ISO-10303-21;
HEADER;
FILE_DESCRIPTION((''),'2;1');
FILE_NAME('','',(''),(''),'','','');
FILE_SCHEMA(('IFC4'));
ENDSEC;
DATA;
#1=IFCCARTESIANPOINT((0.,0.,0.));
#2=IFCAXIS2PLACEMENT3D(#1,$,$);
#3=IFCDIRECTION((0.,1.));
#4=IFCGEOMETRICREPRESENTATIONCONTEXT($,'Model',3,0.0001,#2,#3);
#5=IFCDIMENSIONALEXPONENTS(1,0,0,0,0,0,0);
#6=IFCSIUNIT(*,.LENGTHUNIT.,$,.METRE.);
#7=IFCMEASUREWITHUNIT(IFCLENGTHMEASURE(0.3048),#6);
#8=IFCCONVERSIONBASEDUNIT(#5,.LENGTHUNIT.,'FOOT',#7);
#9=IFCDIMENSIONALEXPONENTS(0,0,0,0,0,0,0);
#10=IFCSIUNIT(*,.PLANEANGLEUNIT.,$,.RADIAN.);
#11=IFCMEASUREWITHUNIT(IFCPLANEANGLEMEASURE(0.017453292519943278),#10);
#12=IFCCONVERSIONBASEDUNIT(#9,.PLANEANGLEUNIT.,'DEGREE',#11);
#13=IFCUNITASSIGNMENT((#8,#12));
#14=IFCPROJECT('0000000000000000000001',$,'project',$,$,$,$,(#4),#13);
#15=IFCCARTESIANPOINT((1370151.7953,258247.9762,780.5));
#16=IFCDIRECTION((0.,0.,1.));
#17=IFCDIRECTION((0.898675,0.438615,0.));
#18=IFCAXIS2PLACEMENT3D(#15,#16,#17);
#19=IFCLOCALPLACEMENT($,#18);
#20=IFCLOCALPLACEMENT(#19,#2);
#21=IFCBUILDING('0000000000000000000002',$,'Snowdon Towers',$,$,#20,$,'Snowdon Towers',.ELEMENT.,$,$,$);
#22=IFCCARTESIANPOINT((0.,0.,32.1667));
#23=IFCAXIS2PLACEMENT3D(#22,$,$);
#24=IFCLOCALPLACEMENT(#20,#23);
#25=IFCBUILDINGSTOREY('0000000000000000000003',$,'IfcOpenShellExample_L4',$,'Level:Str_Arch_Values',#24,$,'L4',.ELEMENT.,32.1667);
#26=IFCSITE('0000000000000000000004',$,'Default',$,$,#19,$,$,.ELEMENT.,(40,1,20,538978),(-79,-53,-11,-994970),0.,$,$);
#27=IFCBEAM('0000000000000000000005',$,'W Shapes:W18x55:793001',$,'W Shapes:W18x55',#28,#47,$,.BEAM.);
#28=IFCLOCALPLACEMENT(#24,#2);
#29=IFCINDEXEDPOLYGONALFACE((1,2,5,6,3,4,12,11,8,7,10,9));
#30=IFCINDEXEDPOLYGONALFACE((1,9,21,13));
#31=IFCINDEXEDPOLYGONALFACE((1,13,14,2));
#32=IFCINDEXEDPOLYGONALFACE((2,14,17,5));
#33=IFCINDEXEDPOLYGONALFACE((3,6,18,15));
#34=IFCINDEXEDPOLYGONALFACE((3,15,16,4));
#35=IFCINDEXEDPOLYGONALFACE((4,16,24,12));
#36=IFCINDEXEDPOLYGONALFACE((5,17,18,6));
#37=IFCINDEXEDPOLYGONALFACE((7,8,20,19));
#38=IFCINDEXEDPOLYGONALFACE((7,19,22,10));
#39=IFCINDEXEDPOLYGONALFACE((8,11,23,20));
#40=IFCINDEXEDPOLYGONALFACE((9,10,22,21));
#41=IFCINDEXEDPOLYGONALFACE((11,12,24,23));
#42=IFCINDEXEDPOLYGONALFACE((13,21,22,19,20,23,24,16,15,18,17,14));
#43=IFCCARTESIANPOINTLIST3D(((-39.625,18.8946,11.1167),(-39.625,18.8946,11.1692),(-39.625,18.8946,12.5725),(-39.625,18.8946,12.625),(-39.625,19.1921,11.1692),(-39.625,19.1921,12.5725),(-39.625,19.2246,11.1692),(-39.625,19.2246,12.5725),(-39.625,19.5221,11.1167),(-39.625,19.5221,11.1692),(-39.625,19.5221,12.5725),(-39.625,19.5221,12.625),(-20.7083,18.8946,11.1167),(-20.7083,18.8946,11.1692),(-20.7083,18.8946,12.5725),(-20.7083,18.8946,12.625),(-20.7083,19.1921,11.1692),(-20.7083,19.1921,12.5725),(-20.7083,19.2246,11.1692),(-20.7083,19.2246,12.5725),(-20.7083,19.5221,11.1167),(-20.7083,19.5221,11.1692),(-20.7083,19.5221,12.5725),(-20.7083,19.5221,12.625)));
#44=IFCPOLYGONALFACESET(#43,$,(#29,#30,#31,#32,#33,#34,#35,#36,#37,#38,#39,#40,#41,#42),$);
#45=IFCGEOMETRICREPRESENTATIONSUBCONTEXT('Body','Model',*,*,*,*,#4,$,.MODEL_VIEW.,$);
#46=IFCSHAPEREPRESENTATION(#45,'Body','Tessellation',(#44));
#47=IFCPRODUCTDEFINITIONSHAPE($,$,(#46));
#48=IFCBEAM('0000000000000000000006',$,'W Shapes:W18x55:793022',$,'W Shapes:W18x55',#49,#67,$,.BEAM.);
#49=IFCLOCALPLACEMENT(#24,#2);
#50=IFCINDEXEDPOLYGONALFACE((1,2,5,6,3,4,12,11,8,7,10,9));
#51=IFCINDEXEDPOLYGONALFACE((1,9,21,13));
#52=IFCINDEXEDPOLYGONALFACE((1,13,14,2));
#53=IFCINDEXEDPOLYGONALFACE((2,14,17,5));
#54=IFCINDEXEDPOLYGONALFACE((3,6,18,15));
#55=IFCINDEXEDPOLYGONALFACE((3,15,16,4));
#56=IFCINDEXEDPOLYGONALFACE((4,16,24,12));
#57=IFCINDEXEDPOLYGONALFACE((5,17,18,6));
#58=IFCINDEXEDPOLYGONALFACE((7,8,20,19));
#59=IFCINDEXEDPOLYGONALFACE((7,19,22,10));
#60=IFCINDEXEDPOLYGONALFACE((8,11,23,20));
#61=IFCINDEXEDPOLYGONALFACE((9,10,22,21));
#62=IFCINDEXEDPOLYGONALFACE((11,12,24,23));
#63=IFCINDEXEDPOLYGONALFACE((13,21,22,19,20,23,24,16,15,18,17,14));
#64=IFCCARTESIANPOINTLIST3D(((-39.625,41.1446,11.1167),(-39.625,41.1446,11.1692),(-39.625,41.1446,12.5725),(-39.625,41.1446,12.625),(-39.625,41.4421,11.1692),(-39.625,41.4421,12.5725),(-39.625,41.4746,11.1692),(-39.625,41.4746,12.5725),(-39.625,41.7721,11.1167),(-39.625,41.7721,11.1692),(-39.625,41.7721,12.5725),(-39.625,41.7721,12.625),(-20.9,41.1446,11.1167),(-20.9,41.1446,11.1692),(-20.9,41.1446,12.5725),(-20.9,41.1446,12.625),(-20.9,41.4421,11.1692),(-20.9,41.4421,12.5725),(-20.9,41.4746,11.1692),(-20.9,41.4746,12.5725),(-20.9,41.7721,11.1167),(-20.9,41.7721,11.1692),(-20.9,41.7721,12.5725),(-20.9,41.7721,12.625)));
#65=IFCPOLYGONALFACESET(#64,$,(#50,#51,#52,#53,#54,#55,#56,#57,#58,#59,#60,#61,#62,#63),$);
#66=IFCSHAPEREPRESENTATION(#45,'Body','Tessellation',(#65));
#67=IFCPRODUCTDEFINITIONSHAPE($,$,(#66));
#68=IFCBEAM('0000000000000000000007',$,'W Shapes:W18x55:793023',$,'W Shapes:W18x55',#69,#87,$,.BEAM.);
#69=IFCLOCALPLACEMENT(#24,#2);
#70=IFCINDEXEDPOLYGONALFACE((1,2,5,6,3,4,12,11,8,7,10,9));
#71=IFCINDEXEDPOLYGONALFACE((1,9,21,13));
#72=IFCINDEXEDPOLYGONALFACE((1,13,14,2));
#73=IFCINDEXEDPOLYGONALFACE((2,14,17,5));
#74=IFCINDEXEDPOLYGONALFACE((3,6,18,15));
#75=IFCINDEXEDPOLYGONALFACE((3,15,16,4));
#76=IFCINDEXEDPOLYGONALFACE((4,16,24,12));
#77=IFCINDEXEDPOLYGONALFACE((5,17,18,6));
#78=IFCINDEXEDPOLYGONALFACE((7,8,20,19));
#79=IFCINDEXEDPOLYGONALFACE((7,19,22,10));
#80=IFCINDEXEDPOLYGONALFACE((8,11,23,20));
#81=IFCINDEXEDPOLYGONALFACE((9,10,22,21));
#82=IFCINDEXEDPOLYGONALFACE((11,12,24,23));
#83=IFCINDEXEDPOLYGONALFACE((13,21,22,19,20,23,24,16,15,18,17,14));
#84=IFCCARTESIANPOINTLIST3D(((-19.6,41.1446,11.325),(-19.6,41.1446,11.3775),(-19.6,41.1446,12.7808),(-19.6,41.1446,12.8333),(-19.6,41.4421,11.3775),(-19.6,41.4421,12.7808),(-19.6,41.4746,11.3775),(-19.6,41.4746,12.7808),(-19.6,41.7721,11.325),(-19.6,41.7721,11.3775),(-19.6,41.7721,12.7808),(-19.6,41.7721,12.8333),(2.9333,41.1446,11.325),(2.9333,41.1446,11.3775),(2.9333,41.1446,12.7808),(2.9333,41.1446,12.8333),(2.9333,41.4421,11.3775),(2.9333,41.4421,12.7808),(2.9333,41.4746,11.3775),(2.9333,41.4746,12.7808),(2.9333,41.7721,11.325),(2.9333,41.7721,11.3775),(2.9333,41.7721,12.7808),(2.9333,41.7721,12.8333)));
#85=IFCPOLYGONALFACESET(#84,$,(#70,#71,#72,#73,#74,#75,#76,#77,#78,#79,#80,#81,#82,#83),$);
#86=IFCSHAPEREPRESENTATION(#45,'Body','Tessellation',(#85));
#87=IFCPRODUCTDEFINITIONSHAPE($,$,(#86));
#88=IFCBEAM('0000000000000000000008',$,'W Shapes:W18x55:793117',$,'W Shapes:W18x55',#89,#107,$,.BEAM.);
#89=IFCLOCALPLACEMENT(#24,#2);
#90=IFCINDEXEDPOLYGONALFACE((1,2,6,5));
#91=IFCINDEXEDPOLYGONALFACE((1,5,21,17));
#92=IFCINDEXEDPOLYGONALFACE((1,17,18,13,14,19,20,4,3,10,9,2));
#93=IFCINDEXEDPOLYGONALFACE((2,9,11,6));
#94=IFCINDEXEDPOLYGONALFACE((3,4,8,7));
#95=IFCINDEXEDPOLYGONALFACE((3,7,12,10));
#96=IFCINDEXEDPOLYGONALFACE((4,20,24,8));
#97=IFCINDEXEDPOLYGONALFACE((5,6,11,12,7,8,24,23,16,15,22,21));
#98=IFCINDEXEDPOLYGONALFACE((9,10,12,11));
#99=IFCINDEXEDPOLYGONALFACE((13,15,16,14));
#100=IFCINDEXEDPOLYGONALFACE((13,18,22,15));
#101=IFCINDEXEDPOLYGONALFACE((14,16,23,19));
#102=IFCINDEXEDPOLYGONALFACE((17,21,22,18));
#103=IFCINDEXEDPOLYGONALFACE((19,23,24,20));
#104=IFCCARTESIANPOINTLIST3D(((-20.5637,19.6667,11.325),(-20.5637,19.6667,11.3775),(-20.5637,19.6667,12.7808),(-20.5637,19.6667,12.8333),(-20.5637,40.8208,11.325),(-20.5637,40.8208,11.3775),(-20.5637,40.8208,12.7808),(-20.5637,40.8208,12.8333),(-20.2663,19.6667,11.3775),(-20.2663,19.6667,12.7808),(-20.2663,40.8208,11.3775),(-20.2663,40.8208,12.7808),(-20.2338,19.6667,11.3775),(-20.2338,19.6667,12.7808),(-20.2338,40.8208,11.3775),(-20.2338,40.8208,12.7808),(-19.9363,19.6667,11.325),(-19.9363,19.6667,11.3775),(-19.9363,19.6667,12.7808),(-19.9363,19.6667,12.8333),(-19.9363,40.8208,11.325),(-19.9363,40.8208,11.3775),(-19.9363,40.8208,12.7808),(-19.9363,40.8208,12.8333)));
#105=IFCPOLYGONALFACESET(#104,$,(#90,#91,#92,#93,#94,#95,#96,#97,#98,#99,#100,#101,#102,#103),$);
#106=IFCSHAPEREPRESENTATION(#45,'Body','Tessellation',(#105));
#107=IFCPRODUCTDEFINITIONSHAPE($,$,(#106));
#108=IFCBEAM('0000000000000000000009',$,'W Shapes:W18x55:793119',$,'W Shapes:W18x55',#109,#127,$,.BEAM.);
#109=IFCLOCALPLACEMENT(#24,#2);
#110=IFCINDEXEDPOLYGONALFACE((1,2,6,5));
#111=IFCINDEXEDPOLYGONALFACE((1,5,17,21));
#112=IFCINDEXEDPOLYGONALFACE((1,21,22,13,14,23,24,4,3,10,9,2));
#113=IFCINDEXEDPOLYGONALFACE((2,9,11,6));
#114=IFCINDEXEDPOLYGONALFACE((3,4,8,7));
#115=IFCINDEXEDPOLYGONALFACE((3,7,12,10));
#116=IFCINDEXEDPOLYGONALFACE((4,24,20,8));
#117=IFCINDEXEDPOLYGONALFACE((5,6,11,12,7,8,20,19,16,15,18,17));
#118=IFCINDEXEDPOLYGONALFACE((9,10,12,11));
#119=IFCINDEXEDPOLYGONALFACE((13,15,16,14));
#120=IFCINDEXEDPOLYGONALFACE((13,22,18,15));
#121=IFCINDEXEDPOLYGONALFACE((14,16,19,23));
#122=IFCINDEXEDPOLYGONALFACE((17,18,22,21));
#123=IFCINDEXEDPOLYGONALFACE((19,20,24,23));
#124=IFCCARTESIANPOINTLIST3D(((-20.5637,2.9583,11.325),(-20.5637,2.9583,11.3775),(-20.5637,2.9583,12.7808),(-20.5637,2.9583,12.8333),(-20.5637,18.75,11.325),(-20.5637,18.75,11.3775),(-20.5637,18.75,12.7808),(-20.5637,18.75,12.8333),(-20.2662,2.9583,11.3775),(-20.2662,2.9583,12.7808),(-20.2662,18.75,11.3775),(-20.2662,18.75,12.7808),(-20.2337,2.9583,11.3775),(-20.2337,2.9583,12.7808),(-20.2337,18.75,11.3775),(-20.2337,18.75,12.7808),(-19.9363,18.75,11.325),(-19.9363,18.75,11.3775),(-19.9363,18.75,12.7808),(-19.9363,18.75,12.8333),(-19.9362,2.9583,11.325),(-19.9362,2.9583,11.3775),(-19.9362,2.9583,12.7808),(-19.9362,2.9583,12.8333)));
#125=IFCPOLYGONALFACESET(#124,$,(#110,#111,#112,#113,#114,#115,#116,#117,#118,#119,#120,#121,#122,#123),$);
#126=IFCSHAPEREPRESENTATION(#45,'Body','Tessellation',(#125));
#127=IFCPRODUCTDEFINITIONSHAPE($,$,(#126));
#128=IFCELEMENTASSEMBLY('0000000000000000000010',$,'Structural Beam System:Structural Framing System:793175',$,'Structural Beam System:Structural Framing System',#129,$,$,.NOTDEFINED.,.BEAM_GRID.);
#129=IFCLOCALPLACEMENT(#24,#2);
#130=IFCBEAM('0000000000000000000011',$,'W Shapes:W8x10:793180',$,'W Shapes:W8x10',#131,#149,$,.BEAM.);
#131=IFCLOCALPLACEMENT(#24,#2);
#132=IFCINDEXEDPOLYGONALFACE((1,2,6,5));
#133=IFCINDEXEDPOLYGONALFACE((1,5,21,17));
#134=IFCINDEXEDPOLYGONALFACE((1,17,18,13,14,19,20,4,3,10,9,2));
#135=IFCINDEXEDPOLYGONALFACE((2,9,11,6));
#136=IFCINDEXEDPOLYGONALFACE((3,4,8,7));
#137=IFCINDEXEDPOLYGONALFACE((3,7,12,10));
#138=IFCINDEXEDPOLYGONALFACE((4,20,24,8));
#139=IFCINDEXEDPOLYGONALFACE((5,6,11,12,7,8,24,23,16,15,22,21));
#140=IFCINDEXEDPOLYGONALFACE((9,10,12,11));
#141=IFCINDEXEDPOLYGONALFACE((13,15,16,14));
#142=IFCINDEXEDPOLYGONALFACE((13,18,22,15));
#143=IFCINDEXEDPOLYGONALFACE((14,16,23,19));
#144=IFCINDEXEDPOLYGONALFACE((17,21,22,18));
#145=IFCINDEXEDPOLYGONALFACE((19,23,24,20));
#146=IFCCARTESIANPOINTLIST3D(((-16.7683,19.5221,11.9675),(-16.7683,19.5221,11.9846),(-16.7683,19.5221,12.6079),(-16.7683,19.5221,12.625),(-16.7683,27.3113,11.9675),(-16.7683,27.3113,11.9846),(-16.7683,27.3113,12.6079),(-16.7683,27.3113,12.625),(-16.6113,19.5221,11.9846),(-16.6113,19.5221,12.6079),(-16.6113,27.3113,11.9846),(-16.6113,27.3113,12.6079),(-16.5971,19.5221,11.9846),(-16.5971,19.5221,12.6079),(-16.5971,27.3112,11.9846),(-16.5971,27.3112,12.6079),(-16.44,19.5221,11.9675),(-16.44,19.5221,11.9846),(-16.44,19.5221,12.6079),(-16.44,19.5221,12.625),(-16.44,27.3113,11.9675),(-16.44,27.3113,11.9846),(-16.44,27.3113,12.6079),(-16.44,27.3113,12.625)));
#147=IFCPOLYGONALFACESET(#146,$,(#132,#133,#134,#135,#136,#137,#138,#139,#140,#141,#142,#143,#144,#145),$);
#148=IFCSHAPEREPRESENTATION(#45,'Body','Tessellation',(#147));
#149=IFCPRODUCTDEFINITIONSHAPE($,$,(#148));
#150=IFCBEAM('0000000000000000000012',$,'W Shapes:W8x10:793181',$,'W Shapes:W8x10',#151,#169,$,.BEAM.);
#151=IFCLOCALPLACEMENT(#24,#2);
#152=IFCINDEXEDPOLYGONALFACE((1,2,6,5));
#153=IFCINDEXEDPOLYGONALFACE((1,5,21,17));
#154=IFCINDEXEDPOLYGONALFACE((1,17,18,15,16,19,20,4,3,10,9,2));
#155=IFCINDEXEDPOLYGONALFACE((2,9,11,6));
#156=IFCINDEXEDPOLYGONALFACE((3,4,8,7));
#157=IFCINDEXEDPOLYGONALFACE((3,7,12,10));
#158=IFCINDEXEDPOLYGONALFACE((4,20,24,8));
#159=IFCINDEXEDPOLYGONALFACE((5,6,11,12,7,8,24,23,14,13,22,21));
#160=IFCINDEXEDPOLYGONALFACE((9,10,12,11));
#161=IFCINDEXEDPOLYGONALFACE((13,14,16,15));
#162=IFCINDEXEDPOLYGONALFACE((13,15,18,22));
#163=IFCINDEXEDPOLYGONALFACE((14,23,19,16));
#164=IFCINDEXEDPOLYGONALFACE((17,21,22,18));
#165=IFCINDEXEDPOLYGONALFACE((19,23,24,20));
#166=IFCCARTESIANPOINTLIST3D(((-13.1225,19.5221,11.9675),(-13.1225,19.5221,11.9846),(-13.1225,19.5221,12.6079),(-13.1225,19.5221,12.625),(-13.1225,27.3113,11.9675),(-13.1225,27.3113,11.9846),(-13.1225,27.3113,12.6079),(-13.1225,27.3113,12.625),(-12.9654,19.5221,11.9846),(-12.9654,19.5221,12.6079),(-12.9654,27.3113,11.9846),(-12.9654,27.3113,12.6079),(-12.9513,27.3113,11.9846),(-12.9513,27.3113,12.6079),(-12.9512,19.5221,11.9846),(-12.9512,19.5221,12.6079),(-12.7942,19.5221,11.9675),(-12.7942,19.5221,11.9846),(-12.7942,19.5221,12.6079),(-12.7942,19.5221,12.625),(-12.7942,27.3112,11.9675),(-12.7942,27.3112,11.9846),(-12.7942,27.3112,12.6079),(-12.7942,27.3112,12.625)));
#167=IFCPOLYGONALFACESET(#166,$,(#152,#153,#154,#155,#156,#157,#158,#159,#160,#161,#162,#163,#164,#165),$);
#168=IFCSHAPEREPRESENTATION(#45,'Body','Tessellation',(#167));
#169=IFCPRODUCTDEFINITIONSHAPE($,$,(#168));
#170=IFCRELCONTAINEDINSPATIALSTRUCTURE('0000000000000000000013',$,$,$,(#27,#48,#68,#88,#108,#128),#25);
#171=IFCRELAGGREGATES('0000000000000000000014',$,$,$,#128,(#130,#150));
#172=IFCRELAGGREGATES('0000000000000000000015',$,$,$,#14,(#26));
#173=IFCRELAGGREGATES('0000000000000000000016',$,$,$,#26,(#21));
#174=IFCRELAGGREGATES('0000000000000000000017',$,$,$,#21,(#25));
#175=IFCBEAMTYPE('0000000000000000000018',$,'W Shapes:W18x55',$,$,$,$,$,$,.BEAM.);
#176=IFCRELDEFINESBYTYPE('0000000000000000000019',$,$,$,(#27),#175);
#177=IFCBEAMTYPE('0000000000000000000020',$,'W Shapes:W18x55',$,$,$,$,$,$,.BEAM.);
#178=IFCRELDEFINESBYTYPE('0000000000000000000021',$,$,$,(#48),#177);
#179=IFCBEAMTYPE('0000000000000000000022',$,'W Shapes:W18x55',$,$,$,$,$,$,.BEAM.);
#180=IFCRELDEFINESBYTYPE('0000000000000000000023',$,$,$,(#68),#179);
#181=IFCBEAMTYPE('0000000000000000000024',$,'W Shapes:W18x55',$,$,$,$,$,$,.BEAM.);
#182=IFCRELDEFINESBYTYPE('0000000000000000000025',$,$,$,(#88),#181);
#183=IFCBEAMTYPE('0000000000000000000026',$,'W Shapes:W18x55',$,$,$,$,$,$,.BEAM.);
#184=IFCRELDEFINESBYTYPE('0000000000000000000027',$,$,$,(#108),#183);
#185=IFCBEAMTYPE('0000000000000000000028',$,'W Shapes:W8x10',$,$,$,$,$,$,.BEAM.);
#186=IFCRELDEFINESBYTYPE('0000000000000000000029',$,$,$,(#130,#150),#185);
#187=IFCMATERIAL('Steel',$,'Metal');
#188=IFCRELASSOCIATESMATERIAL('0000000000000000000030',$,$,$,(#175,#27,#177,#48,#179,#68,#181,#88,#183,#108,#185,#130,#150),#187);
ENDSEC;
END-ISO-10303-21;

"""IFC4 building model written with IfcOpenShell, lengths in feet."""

from ifc_helpers import new_model, entity, si_unit, converted_unit, direction, frame, origin, place, context, subcontext, project, spatial, indexed_curve, outline, extrude, source, transform, mapped, material, type_object, type_shapes, element, aggregate, save


model = new_model("IFC4")

# Units and contexts
model_context = context("Model", 3, precision=0.0001, world=origin(), true_north=direction((0.0, 1.0)))
body_context = subcontext(model_context, "Body", "Model", "MODEL_VIEW")
ifc_project = project(units=[converted_unit("LENGTHUNIT", "FOOT", entity("IfcLengthMeasure", 0.3048), si_unit("LENGTHUNIT", "METRE"), dimensions=[1, 0, 0, 0, 0, 0, 0]), converted_unit("PLANEANGLEUNIT", "DEGREE", entity("IfcPlaneAngleMeasure", 0.017453292519943278), si_unit("PLANEANGLEUNIT", "RADIAN"), dimensions=[0, 0, 0, 0, 0, 0, 0])], contexts=[model_context])

# Site, building, storey
site_placement = place(None, frame((1370151.7953, 258247.9762, 780.5), z_axis=(0.0, 0.0, 1.0), x_axis=(0.898675, 0.438615, 0.0)))
site = spatial("IfcSite", under=ifc_project, at=site_placement, Name="Default", CompositionType="ELEMENT", RefLatitude=(40, 1, 20, 538978), RefLongitude=(-79, -53, -11, -994970), RefElevation=0.0)
building_placement = place(site_placement, origin())
building = spatial("IfcBuilding", under=site, at=building_placement, Name="Snowdon Towers", LongName="Snowdon Towers", CompositionType="ELEMENT")
storey_placement = place(building_placement, frame((0.0, 0.0, 32.1667)))
storey = spatial("IfcBuildingStorey", under=building, at=storey_placement, Name="IfcOpenShellExample_L4", ObjectType="Level:Str_Arch_Values", LongName="L4", CompositionType="ELEMENT", Elevation=32.1667)

# Shared definitions
ifc_material = material(Name="Steel", Category="Metal")

# Beams
beam_type_1 = type_object("IfcBeamType", Name="W Shapes:W18x55", PredefinedType="BEAM", material=ifc_material)
shared_shape_1 = source(origin(), body_context, "Body", "SweptSolid", [
    extrude(outline(indexed_curve([(-0.3138, -0.7017), (-0.3138, -0.7542), (0.3138, -0.7542), (0.3138, -0.7017), (0.0162, -0.7017), (0.0162, 0.7017), (0.3138, 0.7017), (0.3138, 0.7542), (-0.3137, 0.7542), (-0.3137, 0.7017), (-0.0163, 0.7017), (-0.0163, -0.7017), (-0.3138, -0.7017)], self_intersect=False)), frame((-9.5625, 0.0, 0.0), z_axis=(-1.0, 0.0, 0.0), x_axis=(0.0, -1.0, 0.0)), (0.0, 0.0, -1.0), 18.9167),
])
type_shapes(beam_type_1, [shared_shape_1])
beam_1_placement = place(storey_placement, frame((-30.0625, 19.2083, 11.8708)))
element("IfcBeam", 1, at=beam_1_placement, inside=storey, type_object=beam_type_1, material=ifc_material, Name="W Shapes:W18x55:793001", ObjectType="W Shapes:W18x55", PredefinedType="BEAM", context=body_context, shape_type="MappedRepresentation", body=[
    mapped(shared_shape_1, transform((0.0, 0.0, 0.0), scale=1.0)),
])
beam_type_2 = type_object("IfcBeamType", Name="W Shapes:W18x55", PredefinedType="BEAM", material=ifc_material)
shared_shape_2 = source(origin(), body_context, "Body", "SweptSolid", [
    extrude(outline(indexed_curve([(-0.3138, -0.7017), (-0.3138, -0.7542), (0.3138, -0.7542), (0.3138, -0.7017), (0.0162, -0.7017), (0.0162, 0.7017), (0.3138, 0.7017), (0.3138, 0.7542), (-0.3137, 0.7542), (-0.3137, 0.7017), (-0.0163, 0.7017), (-0.0163, -0.7017), (-0.3138, -0.7017)], self_intersect=False)), frame((-9.5625, 0.0, 0.0), z_axis=(-1.0, 0.0, 0.0), x_axis=(0.0, -1.0, 0.0)), (0.0, 0.0, -1.0), 18.725),
])
type_shapes(beam_type_2, [shared_shape_2])
beam_2_placement = place(storey_placement, frame((-30.0625, 41.4583, 11.8708)))
element("IfcBeam", 2, at=beam_2_placement, inside=storey, type_object=beam_type_2, material=ifc_material, Name="W Shapes:W18x55:793022", ObjectType="W Shapes:W18x55", PredefinedType="BEAM", context=body_context, shape_type="MappedRepresentation", body=[
    mapped(shared_shape_2, transform((0.0, 0.0, 0.0), scale=1.0)),
])
beam_type_3 = type_object("IfcBeamType", Name="W Shapes:W18x55", PredefinedType="BEAM", material=ifc_material)
shared_shape_3 = source(origin(), body_context, "Body", "SweptSolid", [
    extrude(outline(indexed_curve([(-0.3138, -0.7017), (-0.3138, -0.7542), (0.3138, -0.7542), (0.3138, -0.7017), (0.0162, -0.7017), (0.0162, 0.7017), (0.3138, 0.7017), (0.3138, 0.7542), (-0.3137, 0.7542), (-0.3137, 0.7017), (-0.0163, 0.7017), (-0.0163, -0.7017), (-0.3138, -0.7017)], self_intersect=False)), frame((-11.35, 0.0, 0.0), z_axis=(-1.0, 0.0, 0.0), x_axis=(0.0, -1.0, 0.0)), (0.0, 0.0, -1.0), 22.5333),
])
type_shapes(beam_type_3, [shared_shape_3])
beam_3_placement = place(storey_placement, frame((-8.25, 41.4583, 12.0792)))
element("IfcBeam", 3, at=beam_3_placement, inside=storey, type_object=beam_type_3, material=ifc_material, Name="W Shapes:W18x55:793023", ObjectType="W Shapes:W18x55", PredefinedType="BEAM", context=body_context, shape_type="MappedRepresentation", body=[
    mapped(shared_shape_3, transform((0.0, 0.0, 0.0), scale=1.0)),
])
beam_type_4 = type_object("IfcBeamType", Name="W Shapes:W18x55", PredefinedType="BEAM", material=ifc_material)
shared_shape_4 = source(origin(), body_context, "Body", "SweptSolid", [
    extrude(outline(indexed_curve([(-0.3138, -0.7017), (-0.3138, -0.7542), (0.3138, -0.7542), (0.3138, -0.7017), (0.0162, -0.7017), (0.0162, 0.7017), (0.3138, 0.7017), (0.3138, 0.7542), (-0.3137, 0.7542), (-0.3137, 0.7017), (-0.0163, 0.7017), (-0.0163, -0.7017), (-0.3138, -0.7017)], self_intersect=False)), frame((-10.4042, 0.0, 0.0), z_axis=(-1.0, 0.0, 0.0), x_axis=(0.0, -1.0, 0.0)), (0.0, 0.0, -1.0), 21.1542),
])
type_shapes(beam_type_4, [shared_shape_4])
beam_4_placement = place(storey_placement, frame((-20.25, 30.4167, 12.0792), z_axis=(0.0, 0.0, 1.0), x_axis=(0.0, -1.0, 0.0)))
element("IfcBeam", 4, at=beam_4_placement, inside=storey, type_object=beam_type_4, material=ifc_material, Name="W Shapes:W18x55:793117", ObjectType="W Shapes:W18x55", PredefinedType="BEAM", context=body_context, shape_type="MappedRepresentation", body=[
    mapped(shared_shape_4, transform((0.0, 0.0, 0.0), scale=1.0)),
])
beam_type_5 = type_object("IfcBeamType", Name="W Shapes:W18x55", PredefinedType="BEAM", material=ifc_material)
shared_shape_5 = source(origin(), body_context, "Body", "SweptSolid", [
    extrude(outline(indexed_curve([(-0.3138, -0.7017), (-0.3138, -0.7542), (0.3138, -0.7542), (0.3138, -0.7017), (0.0162, -0.7017), (0.0162, 0.7017), (0.3138, 0.7017), (0.3138, 0.7542), (-0.3137, 0.7542), (-0.3137, 0.7017), (-0.0163, 0.7017), (-0.0163, -0.7017), (-0.3138, -0.7017)], self_intersect=False)), frame((-7.8958, 0.0, 0.0), z_axis=(-1.0, 0.0, 0.0), x_axis=(0.0, -1.0, 0.0)), (0.0, 0.0, -1.0), 15.7917),
])
type_shapes(beam_type_5, [shared_shape_5])
beam_5_placement = place(storey_placement, frame((-20.25, 10.8542, 12.0792), z_axis=(0.0, 0.0, 1.0), x_axis=(0.0, -1.0, 0.0)))
element("IfcBeam", 5, at=beam_5_placement, inside=storey, type_object=beam_type_5, material=ifc_material, Name="W Shapes:W18x55:793119", ObjectType="W Shapes:W18x55", PredefinedType="BEAM", context=body_context, shape_type="MappedRepresentation", body=[
    mapped(shared_shape_5, transform((0.0, 0.0, 0.0), scale=1.0)),
])

# Element assembly, beams
assembly_1_placement = place(storey_placement, origin())
assembly_1 = element("IfcElementAssembly", 6, at=assembly_1_placement, inside=storey, Name="Structural Beam System:Structural Framing System:793175", ObjectType="Structural Beam System:Structural Framing System", AssemblyPlace="NOTDEFINED", PredefinedType="BEAM_GRID")
beam_type_6 = type_object("IfcBeamType", Name="W Shapes:W8x10", PredefinedType="BEAM", material=ifc_material)
shared_shape_6 = source(origin(), body_context, "Body", "SweptSolid", [
    extrude(outline(indexed_curve([(-0.1642, -0.3117), (-0.1642, -0.3288), (0.1642, -0.3288), (0.1642, -0.3117), (0.0071, -0.3117), (0.0071, 0.3117), (0.1642, 0.3117), (0.1642, 0.3287), (-0.1642, 0.3287), (-0.1642, 0.3117), (-0.0071, 0.3117), (-0.0071, -0.3117), (-0.1642, -0.3117)], self_intersect=False)), frame((-3.8946, 0.0, 0.0), z_axis=(-1.0, 0.0, 0.0), x_axis=(0.0, -1.0, 0.0)), (0.0, 0.0, -1.0), 7.7892),
])
type_shapes(beam_type_6, [shared_shape_6])
beam_6_placement = place(assembly_1_placement, frame((-16.6042, 23.4167, 12.2963), z_axis=(0.0, 0.0, 1.0), x_axis=(0.0, 1.0, 0.0)))
beam_6 = element("IfcBeam", 7, at=beam_6_placement, type_object=beam_type_6, material=ifc_material, Name="W Shapes:W8x10:793180", ObjectType="W Shapes:W8x10", PredefinedType="BEAM", context=body_context, shape_type="MappedRepresentation", body=[
    mapped(shared_shape_6, transform((0.0, 0.0, 0.0), scale=1.0)),
])
beam_7_placement = place(assembly_1_placement, frame((-12.9583, 23.4167, 12.2963), z_axis=(0.0, 0.0, 1.0), x_axis=(0.0, 1.0, 0.0)))
beam_7 = element("IfcBeam", 8, at=beam_7_placement, type_object=beam_type_6, material=ifc_material, Name="W Shapes:W8x10:793181", ObjectType="W Shapes:W8x10", PredefinedType="BEAM", context=body_context, shape_type="MappedRepresentation", body=[
    mapped(shared_shape_6, transform((0.0, 0.0, 0.0), scale=1.0)),
])
aggregate(assembly_1, [beam_6, beam_7])

save(model, "model.ifc")
